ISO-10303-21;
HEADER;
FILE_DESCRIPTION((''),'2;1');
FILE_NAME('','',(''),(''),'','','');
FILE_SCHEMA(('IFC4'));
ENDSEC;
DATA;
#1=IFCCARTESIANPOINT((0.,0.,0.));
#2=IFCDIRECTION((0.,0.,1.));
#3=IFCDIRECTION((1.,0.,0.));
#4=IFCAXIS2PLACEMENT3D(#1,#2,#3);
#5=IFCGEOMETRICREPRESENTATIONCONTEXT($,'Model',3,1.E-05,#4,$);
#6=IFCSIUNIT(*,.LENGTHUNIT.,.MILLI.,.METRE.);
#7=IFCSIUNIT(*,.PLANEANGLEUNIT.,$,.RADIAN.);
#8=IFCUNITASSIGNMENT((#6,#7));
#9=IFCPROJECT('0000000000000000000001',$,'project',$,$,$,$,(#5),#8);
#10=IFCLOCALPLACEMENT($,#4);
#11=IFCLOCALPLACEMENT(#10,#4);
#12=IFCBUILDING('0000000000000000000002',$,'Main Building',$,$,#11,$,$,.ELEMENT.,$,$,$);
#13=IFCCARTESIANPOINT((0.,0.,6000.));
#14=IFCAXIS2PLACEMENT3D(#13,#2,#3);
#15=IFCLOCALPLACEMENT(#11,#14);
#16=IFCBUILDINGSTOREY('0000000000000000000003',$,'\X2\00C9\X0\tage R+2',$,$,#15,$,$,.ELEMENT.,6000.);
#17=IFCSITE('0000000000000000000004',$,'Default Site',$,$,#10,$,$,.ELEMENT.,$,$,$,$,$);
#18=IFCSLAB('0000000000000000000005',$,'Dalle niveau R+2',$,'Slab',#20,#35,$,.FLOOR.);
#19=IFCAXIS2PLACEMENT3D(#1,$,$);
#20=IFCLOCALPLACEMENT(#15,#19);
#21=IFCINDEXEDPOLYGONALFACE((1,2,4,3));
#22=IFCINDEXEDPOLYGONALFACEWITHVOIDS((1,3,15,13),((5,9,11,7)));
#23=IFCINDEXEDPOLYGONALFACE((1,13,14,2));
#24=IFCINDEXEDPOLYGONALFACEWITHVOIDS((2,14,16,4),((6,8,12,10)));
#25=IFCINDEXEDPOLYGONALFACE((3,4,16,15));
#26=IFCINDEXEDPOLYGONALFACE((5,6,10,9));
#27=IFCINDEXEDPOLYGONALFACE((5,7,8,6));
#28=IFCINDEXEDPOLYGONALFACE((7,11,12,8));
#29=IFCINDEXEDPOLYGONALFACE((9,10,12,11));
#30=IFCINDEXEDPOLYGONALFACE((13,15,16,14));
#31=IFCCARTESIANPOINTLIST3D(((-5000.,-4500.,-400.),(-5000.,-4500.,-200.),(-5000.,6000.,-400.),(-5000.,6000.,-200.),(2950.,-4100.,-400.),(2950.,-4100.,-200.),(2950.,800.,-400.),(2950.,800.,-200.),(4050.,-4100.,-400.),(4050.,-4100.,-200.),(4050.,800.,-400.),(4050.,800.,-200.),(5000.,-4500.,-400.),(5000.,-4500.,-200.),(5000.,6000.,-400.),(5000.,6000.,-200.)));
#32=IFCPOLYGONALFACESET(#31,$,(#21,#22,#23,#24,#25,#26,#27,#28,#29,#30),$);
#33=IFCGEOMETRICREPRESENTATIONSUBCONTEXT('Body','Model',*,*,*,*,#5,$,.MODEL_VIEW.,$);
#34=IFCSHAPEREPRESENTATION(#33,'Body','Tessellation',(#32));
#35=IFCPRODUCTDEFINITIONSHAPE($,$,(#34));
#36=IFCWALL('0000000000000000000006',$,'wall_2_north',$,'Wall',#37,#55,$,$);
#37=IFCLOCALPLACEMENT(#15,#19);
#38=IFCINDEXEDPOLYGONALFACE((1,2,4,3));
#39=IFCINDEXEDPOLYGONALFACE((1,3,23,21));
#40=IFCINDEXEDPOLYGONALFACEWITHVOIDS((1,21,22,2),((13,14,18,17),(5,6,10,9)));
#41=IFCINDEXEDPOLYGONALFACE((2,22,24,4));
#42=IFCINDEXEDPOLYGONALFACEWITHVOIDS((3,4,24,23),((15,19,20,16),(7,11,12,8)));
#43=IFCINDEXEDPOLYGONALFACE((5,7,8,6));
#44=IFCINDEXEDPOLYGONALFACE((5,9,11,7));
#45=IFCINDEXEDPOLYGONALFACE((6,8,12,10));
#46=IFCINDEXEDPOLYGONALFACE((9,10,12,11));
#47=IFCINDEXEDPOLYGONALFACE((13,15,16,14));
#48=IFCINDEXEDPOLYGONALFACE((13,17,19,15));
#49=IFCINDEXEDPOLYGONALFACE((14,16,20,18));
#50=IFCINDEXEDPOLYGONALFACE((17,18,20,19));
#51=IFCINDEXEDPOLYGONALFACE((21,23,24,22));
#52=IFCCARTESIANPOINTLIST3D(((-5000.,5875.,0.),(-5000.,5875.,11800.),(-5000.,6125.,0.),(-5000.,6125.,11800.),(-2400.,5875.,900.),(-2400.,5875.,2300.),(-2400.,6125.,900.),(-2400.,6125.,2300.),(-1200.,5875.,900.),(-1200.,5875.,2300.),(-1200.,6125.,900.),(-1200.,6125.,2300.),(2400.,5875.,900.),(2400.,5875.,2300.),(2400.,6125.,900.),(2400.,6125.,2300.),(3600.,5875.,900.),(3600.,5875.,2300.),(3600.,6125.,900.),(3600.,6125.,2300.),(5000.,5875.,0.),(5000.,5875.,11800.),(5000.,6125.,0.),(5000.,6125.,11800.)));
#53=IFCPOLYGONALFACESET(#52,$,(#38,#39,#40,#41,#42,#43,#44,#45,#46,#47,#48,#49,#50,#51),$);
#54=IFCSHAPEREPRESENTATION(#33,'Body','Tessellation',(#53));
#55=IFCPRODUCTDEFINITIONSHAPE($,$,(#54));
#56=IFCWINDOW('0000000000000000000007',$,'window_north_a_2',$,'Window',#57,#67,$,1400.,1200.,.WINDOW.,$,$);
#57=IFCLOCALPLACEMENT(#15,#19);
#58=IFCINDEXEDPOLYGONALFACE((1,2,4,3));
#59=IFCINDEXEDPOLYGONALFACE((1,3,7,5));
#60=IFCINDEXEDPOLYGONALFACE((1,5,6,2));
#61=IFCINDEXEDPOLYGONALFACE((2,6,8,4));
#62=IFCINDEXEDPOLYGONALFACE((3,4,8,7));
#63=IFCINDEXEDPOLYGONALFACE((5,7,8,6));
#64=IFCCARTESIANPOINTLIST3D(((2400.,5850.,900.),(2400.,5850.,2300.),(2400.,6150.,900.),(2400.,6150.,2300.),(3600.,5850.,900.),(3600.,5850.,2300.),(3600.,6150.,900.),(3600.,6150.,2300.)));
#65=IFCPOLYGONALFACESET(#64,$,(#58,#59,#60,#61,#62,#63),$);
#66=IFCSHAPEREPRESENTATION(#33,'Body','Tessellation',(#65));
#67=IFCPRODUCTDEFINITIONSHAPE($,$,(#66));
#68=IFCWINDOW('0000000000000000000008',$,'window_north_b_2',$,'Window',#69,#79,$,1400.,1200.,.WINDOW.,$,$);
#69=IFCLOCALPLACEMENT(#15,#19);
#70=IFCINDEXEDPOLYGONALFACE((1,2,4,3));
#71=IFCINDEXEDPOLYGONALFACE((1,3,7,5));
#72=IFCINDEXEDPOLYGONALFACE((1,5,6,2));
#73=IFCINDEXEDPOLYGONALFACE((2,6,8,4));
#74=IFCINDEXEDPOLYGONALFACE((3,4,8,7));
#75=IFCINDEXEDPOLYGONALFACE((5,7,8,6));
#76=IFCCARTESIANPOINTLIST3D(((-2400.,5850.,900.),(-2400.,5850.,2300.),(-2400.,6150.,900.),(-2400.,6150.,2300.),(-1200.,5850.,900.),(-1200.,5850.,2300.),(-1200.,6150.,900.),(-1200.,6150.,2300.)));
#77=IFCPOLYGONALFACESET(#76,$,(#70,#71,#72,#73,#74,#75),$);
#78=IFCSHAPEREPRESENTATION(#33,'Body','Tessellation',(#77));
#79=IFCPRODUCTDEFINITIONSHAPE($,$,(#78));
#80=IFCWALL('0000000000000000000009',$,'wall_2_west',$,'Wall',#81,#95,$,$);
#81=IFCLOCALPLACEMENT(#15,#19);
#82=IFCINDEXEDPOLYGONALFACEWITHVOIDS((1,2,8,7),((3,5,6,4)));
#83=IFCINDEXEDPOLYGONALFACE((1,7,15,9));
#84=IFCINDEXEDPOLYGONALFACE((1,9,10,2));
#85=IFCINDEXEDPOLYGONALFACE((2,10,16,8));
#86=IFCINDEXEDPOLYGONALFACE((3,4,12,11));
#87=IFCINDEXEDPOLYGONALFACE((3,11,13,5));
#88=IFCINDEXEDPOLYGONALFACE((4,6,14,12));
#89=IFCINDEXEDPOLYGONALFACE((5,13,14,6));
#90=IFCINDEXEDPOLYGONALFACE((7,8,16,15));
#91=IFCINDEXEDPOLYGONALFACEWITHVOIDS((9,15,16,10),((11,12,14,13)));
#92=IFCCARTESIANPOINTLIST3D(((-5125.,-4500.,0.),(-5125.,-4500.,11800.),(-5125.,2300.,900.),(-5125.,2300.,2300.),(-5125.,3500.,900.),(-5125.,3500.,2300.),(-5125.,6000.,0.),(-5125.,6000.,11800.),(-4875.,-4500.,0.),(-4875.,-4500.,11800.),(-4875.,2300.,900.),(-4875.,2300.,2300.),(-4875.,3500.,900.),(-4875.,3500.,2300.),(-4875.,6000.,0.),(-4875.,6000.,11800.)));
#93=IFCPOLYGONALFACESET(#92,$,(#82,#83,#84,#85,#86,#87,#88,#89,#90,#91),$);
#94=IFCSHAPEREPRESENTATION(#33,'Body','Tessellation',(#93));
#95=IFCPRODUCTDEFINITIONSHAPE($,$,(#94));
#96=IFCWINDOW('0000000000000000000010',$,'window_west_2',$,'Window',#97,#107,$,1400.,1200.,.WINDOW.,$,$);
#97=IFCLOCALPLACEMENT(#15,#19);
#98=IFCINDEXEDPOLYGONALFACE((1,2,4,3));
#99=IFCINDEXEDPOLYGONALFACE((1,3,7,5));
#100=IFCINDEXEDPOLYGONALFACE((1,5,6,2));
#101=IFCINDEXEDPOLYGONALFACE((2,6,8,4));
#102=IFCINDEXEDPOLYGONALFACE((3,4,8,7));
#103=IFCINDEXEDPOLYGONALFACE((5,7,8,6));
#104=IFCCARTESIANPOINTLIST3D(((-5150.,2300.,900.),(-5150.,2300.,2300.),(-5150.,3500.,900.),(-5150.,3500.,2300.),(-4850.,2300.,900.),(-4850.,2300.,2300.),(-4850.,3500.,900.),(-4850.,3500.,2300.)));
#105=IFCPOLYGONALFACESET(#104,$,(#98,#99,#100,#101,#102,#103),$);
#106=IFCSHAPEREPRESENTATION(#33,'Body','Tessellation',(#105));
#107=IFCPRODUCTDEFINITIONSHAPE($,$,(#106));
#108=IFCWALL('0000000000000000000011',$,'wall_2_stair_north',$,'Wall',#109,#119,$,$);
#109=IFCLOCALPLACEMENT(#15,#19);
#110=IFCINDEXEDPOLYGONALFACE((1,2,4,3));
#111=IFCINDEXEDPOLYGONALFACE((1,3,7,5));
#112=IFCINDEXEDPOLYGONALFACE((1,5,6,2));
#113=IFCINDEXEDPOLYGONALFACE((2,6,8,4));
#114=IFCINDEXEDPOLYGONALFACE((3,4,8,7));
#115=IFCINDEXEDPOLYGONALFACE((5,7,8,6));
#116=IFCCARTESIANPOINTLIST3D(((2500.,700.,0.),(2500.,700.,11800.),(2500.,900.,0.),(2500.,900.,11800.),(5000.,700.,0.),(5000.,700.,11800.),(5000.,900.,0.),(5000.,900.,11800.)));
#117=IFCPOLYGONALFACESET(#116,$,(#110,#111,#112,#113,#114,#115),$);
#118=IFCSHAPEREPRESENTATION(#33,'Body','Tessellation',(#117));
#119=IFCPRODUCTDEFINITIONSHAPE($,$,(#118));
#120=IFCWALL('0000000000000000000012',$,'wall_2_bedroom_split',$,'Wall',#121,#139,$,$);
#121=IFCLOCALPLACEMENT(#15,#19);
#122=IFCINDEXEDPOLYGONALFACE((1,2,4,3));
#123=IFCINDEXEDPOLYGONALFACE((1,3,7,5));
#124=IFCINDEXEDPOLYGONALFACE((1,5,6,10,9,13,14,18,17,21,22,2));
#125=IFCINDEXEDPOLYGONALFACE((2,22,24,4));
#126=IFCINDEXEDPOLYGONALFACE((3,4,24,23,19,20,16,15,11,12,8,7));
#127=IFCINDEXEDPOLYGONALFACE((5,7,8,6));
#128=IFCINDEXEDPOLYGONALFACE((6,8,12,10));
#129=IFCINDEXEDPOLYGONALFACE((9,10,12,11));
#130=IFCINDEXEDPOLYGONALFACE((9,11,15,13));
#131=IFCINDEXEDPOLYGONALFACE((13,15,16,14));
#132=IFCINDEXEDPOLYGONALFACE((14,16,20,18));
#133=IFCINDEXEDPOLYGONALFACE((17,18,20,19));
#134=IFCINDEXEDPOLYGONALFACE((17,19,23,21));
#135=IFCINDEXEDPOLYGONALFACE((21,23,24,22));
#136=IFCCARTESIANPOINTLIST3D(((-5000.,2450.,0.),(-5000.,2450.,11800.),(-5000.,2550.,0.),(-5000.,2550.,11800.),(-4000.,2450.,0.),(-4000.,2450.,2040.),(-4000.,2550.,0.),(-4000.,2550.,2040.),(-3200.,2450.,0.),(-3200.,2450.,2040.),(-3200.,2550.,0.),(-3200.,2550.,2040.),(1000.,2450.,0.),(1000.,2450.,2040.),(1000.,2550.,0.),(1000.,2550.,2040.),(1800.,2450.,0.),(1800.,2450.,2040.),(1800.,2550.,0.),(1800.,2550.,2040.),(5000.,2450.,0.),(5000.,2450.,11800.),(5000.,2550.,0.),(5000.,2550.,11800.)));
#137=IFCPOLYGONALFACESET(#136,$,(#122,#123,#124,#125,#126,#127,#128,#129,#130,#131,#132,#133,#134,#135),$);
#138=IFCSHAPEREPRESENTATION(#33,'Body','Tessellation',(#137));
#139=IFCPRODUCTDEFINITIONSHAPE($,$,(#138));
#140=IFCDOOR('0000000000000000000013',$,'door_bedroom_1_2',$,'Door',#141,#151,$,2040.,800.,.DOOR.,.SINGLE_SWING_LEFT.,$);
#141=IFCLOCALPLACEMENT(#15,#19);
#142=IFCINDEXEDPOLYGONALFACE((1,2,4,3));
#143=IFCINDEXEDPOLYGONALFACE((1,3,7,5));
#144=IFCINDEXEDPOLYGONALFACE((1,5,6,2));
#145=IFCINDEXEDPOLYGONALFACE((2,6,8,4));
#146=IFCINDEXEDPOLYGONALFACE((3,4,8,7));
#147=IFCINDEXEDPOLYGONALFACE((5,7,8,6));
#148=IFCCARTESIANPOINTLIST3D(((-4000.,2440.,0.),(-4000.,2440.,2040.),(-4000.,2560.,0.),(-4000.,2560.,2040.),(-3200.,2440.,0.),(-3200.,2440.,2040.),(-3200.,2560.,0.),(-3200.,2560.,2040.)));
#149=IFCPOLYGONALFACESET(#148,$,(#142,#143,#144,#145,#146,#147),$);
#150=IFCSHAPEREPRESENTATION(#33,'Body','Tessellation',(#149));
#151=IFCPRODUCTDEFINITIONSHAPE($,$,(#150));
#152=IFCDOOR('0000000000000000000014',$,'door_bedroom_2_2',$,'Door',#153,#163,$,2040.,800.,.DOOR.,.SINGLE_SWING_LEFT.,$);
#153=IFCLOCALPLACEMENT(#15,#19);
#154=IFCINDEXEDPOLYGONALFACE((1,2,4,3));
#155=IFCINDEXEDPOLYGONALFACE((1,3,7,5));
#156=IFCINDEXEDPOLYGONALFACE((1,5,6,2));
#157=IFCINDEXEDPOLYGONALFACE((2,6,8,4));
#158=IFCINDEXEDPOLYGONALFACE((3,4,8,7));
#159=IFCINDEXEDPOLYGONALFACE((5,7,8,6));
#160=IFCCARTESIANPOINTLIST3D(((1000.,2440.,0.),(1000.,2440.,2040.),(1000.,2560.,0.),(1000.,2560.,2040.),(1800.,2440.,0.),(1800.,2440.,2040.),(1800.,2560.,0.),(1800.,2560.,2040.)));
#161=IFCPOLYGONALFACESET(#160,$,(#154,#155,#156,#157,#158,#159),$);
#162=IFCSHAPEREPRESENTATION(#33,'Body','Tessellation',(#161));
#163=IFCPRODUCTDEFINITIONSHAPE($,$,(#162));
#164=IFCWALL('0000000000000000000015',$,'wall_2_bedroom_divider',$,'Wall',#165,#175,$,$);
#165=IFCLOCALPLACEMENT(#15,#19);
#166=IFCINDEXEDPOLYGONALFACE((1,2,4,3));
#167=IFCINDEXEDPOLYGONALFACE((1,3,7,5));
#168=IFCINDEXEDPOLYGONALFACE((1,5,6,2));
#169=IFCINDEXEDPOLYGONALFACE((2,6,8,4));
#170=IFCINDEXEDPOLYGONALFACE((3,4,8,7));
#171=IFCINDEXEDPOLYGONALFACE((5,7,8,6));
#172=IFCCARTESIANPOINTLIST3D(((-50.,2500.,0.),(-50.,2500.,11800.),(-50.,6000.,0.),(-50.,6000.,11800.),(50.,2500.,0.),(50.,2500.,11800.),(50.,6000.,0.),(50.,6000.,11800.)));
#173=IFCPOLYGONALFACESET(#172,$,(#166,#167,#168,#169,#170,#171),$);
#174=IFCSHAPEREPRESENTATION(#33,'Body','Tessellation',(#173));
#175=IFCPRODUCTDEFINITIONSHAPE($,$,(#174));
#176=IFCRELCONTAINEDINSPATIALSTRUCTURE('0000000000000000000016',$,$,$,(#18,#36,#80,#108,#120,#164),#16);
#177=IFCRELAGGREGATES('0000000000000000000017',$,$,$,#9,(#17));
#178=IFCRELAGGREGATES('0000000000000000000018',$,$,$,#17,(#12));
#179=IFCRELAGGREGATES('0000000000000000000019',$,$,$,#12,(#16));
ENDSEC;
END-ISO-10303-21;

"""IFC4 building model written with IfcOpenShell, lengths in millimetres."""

from ifc_helpers import new_model, si_unit, frame, origin_with_axes, place, context, subcontext, project, spatial, polyline, outline, extrude, element, fill, save


model = new_model("IFC4")

# Units and contexts
model_context = context("Model", 3, precision=1e-05, world=origin_with_axes())
body_context = subcontext(model_context, "Body", "Model", "MODEL_VIEW")
ifc_project = project(units=[si_unit("LENGTHUNIT", "METRE", prefix="MILLI"), si_unit("PLANEANGLEUNIT", "RADIAN")], contexts=[model_context])

# Site, building, storey
site_placement = place(None, origin_with_axes())
site = spatial("IfcSite", under=ifc_project, at=site_placement, Name="Default Site", CompositionType="ELEMENT")
building_placement = place(site_placement, origin_with_axes())
building = spatial("IfcBuilding", under=site, at=building_placement, Name="Main Building", CompositionType="ELEMENT")
storey_placement = place(building_placement, frame((0.0, 0.0, 6000.0), z_axis=(0.0, 0.0, 1.0), x_axis=(1.0, 0.0, 0.0)))
storey = spatial("IfcBuildingStorey", under=building, at=storey_placement, Name="Étage R+2", CompositionType="ELEMENT", Elevation=6000.0)

# Slab
slab_placement = place(storey_placement, frame((0.0, 0.0, -400.0), z_axis=(0.0, 0.0, 1.0), x_axis=(1.0, 0.0, 0.0)))
element("IfcSlab", 1, at=slab_placement, inside=storey, Name="Dalle niveau R+2", ObjectType="Slab", PredefinedType="FLOOR", context=body_context, shape_type="SweptSolid", body=[
    extrude(outline(polyline([(-5000.0, -4500.0), (5000.0, -4500.0), (5000.0, 6000.0), (-5000.0, 6000.0), (-5000.0, -4500.0)]), holes=[polyline([(2950.0, -4100.0), (2950.0, 800.0), (4050.0, 800.0), (4050.0, -4100.0), (2950.0, -4100.0)])]), origin_with_axes(), (0.0, 0.0, 1.0), 200.0),
])

# Wall, openings, windows
wall_1_placement = place(storey_placement, frame((5000.0, 6000.0, 0.0), z_axis=(0.0, 0.0, 1.0), x_axis=(-1.0, 0.0, 0.0)))
wall_1 = element("IfcWall", 2, at=wall_1_placement, inside=storey, Name="wall_2_north", ObjectType="Wall", context=body_context, shape_type="SweptSolid", body=[
    extrude(outline(polyline([(0.0, -125.0), (10000.0, -125.0), (10000.0, 125.0), (0.0, 125.0), (0.0, -125.0)])), origin_with_axes(), (0.0, 0.0, 1.0), 11800.0),
])
placement_1 = place(wall_1_placement, frame((1400.0, 0.0, 900.0), z_axis=(0.0, 0.0, 1.0), x_axis=(1.0, 0.0, 0.0)))
opening_1 = element("IfcOpeningElement", 3, at=placement_1, cuts=wall_1, PredefinedType="OPENING", context=body_context, shape_type="SweptSolid", body=[
    extrude(outline(polyline([(0.0, -150.0), (1200.0, -150.0), (1200.0, 150.0), (0.0, 150.0), (0.0, -150.0)])), origin_with_axes(), (0.0, 0.0, 1.0), 1400.0),
])
placement_2 = place(wall_1_placement, frame((6200.0, 0.0, 900.0), z_axis=(0.0, 0.0, 1.0), x_axis=(1.0, 0.0, 0.0)))
opening_2 = element("IfcOpeningElement", 4, at=placement_2, cuts=wall_1, PredefinedType="OPENING", context=body_context, shape_type="SweptSolid", body=[
    extrude(outline(polyline([(0.0, -150.0), (1200.0, -150.0), (1200.0, 150.0), (0.0, 150.0), (0.0, -150.0)])), origin_with_axes(), (0.0, 0.0, 1.0), 1400.0),
])
window_1 = element("IfcWindow", 5, at=placement_1, Name="window_north_a_2", ObjectType="Window", OverallHeight=1400.0, OverallWidth=1200.0, PredefinedType="WINDOW", context=body_context, shape_type="SweptSolid", body=[
    extrude(outline(polyline([(0.0, -150.0), (1200.0, -150.0), (1200.0, 150.0), (0.0, 150.0), (0.0, -150.0)])), origin_with_axes(), (0.0, 0.0, 1.0), 1400.0),
])
fill(opening_1, window_1)
window_2 = element("IfcWindow", 6, at=placement_2, Name="window_north_b_2", ObjectType="Window", OverallHeight=1400.0, OverallWidth=1200.0, PredefinedType="WINDOW", context=body_context, shape_type="SweptSolid", body=[
    extrude(outline(polyline([(0.0, -150.0), (1200.0, -150.0), (1200.0, 150.0), (0.0, 150.0), (0.0, -150.0)])), origin_with_axes(), (0.0, 0.0, 1.0), 1400.0),
])
fill(opening_2, window_2)

# Wall, opening, window
wall_2_placement = place(storey_placement, frame((-5000.0, 6000.0, 0.0), z_axis=(0.0, 0.0, 1.0), x_axis=(0.0, -1.0, 0.0)))
wall_2 = element("IfcWall", 7, at=wall_2_placement, inside=storey, Name="wall_2_west", ObjectType="Wall", context=body_context, shape_type="SweptSolid", body=[
    extrude(outline(polyline([(0.0, -125.0), (10500.0, -125.0), (10500.0, 125.0), (0.0, 125.0), (0.0, -125.0)])), origin_with_axes(), (0.0, 0.0, 1.0), 11800.0),
])
placement_3 = place(wall_2_placement, frame((2500.0, 0.0, 900.0), z_axis=(0.0, 0.0, 1.0), x_axis=(1.0, 0.0, 0.0)))
opening_3 = element("IfcOpeningElement", 8, at=placement_3, cuts=wall_2, PredefinedType="OPENING", context=body_context, shape_type="SweptSolid", body=[
    extrude(outline(polyline([(0.0, -150.0), (1200.0, -150.0), (1200.0, 150.0), (0.0, 150.0), (0.0, -150.0)])), origin_with_axes(), (0.0, 0.0, 1.0), 1400.0),
])
window_3 = element("IfcWindow", 9, at=placement_3, Name="window_west_2", ObjectType="Window", OverallHeight=1400.0, OverallWidth=1200.0, PredefinedType="WINDOW", context=body_context, shape_type="SweptSolid", body=[
    extrude(outline(polyline([(0.0, -150.0), (1200.0, -150.0), (1200.0, 150.0), (0.0, 150.0), (0.0, -150.0)])), origin_with_axes(), (0.0, 0.0, 1.0), 1400.0),
])
fill(opening_3, window_3)

# Wall
wall_3_placement = place(storey_placement, frame((2500.0, 800.0, 0.0), z_axis=(0.0, 0.0, 1.0), x_axis=(1.0, 0.0, 0.0)))
element("IfcWall", 10, at=wall_3_placement, inside=storey, Name="wall_2_stair_north", ObjectType="Wall", context=body_context, shape_type="SweptSolid", body=[
    extrude(outline(polyline([(0.0, -100.0), (2500.0, -100.0), (2500.0, 100.0), (0.0, 100.0), (0.0, -100.0)])), origin_with_axes(), (0.0, 0.0, 1.0), 11800.0),
])

# Wall, openings, doors
wall_4_placement = place(storey_placement, frame((-5000.0, 2500.0, 0.0), z_axis=(0.0, 0.0, 1.0), x_axis=(1.0, 0.0, 0.0)))
wall_4 = element("IfcWall", 11, at=wall_4_placement, inside=storey, Name="wall_2_bedroom_split", ObjectType="Wall", context=body_context, shape_type="SweptSolid", body=[
    extrude(outline(polyline([(0.0, -50.0), (10000.0, -50.0), (10000.0, 50.0), (0.0, 50.0), (0.0, -50.0)])), origin_with_axes(), (0.0, 0.0, 1.0), 11800.0),
])
placement_4 = place(wall_4_placement, frame((1000.0, 0.0, 0.0), z_axis=(0.0, 0.0, 1.0), x_axis=(1.0, 0.0, 0.0)))
opening_4 = element("IfcOpeningElement", 12, at=placement_4, cuts=wall_4, PredefinedType="OPENING", context=body_context, shape_type="SweptSolid", body=[
    extrude(outline(polyline([(0.0, -60.0), (800.0, -60.0), (800.0, 60.0), (0.0, 60.0), (0.0, -60.0)])), origin_with_axes(), (0.0, 0.0, 1.0), 2040.0),
])
placement_5 = place(wall_4_placement, frame((6000.0, 0.0, 0.0), z_axis=(0.0, 0.0, 1.0), x_axis=(1.0, 0.0, 0.0)))
opening_5 = element("IfcOpeningElement", 13, at=placement_5, cuts=wall_4, PredefinedType="OPENING", context=body_context, shape_type="SweptSolid", body=[
    extrude(outline(polyline([(0.0, -60.0), (800.0, -60.0), (800.0, 60.0), (0.0, 60.0), (0.0, -60.0)])), origin_with_axes(), (0.0, 0.0, 1.0), 2040.0),
])
door_1 = element("IfcDoor", 14, at=placement_4, Name="door_bedroom_1_2", ObjectType="Door", OperationType="SINGLE_SWING_LEFT", OverallHeight=2040.0, OverallWidth=800.0, PredefinedType="DOOR", context=body_context, shape_type="SweptSolid", body=[
    extrude(outline(polyline([(0.0, -60.0), (800.0, -60.0), (800.0, 60.0), (0.0, 60.0), (0.0, -60.0)])), origin_with_axes(), (0.0, 0.0, 1.0), 2040.0),
])
fill(opening_4, door_1)
door_2 = element("IfcDoor", 15, at=placement_5, Name="door_bedroom_2_2", ObjectType="Door", OperationType="SINGLE_SWING_LEFT", OverallHeight=2040.0, OverallWidth=800.0, PredefinedType="DOOR", context=body_context, shape_type="SweptSolid", body=[
    extrude(outline(polyline([(0.0, -60.0), (800.0, -60.0), (800.0, 60.0), (0.0, 60.0), (0.0, -60.0)])), origin_with_axes(), (0.0, 0.0, 1.0), 2040.0),
])
fill(opening_5, door_2)

# Wall
wall_5_placement = place(storey_placement, frame((0.0, 2500.0, 0.0), z_axis=(0.0, 0.0, 1.0), x_axis=(0.0, 1.0, 0.0)))
element("IfcWall", 16, at=wall_5_placement, inside=storey, Name="wall_2_bedroom_divider", ObjectType="Wall", context=body_context, shape_type="SweptSolid", body=[
    extrude(outline(polyline([(0.0, -50.0), (3500.0, -50.0), (3500.0, 50.0), (0.0, 50.0), (0.0, -50.0)])), origin_with_axes(), (0.0, 0.0, 1.0), 11800.0),
])

save(model, "model.ifc")
